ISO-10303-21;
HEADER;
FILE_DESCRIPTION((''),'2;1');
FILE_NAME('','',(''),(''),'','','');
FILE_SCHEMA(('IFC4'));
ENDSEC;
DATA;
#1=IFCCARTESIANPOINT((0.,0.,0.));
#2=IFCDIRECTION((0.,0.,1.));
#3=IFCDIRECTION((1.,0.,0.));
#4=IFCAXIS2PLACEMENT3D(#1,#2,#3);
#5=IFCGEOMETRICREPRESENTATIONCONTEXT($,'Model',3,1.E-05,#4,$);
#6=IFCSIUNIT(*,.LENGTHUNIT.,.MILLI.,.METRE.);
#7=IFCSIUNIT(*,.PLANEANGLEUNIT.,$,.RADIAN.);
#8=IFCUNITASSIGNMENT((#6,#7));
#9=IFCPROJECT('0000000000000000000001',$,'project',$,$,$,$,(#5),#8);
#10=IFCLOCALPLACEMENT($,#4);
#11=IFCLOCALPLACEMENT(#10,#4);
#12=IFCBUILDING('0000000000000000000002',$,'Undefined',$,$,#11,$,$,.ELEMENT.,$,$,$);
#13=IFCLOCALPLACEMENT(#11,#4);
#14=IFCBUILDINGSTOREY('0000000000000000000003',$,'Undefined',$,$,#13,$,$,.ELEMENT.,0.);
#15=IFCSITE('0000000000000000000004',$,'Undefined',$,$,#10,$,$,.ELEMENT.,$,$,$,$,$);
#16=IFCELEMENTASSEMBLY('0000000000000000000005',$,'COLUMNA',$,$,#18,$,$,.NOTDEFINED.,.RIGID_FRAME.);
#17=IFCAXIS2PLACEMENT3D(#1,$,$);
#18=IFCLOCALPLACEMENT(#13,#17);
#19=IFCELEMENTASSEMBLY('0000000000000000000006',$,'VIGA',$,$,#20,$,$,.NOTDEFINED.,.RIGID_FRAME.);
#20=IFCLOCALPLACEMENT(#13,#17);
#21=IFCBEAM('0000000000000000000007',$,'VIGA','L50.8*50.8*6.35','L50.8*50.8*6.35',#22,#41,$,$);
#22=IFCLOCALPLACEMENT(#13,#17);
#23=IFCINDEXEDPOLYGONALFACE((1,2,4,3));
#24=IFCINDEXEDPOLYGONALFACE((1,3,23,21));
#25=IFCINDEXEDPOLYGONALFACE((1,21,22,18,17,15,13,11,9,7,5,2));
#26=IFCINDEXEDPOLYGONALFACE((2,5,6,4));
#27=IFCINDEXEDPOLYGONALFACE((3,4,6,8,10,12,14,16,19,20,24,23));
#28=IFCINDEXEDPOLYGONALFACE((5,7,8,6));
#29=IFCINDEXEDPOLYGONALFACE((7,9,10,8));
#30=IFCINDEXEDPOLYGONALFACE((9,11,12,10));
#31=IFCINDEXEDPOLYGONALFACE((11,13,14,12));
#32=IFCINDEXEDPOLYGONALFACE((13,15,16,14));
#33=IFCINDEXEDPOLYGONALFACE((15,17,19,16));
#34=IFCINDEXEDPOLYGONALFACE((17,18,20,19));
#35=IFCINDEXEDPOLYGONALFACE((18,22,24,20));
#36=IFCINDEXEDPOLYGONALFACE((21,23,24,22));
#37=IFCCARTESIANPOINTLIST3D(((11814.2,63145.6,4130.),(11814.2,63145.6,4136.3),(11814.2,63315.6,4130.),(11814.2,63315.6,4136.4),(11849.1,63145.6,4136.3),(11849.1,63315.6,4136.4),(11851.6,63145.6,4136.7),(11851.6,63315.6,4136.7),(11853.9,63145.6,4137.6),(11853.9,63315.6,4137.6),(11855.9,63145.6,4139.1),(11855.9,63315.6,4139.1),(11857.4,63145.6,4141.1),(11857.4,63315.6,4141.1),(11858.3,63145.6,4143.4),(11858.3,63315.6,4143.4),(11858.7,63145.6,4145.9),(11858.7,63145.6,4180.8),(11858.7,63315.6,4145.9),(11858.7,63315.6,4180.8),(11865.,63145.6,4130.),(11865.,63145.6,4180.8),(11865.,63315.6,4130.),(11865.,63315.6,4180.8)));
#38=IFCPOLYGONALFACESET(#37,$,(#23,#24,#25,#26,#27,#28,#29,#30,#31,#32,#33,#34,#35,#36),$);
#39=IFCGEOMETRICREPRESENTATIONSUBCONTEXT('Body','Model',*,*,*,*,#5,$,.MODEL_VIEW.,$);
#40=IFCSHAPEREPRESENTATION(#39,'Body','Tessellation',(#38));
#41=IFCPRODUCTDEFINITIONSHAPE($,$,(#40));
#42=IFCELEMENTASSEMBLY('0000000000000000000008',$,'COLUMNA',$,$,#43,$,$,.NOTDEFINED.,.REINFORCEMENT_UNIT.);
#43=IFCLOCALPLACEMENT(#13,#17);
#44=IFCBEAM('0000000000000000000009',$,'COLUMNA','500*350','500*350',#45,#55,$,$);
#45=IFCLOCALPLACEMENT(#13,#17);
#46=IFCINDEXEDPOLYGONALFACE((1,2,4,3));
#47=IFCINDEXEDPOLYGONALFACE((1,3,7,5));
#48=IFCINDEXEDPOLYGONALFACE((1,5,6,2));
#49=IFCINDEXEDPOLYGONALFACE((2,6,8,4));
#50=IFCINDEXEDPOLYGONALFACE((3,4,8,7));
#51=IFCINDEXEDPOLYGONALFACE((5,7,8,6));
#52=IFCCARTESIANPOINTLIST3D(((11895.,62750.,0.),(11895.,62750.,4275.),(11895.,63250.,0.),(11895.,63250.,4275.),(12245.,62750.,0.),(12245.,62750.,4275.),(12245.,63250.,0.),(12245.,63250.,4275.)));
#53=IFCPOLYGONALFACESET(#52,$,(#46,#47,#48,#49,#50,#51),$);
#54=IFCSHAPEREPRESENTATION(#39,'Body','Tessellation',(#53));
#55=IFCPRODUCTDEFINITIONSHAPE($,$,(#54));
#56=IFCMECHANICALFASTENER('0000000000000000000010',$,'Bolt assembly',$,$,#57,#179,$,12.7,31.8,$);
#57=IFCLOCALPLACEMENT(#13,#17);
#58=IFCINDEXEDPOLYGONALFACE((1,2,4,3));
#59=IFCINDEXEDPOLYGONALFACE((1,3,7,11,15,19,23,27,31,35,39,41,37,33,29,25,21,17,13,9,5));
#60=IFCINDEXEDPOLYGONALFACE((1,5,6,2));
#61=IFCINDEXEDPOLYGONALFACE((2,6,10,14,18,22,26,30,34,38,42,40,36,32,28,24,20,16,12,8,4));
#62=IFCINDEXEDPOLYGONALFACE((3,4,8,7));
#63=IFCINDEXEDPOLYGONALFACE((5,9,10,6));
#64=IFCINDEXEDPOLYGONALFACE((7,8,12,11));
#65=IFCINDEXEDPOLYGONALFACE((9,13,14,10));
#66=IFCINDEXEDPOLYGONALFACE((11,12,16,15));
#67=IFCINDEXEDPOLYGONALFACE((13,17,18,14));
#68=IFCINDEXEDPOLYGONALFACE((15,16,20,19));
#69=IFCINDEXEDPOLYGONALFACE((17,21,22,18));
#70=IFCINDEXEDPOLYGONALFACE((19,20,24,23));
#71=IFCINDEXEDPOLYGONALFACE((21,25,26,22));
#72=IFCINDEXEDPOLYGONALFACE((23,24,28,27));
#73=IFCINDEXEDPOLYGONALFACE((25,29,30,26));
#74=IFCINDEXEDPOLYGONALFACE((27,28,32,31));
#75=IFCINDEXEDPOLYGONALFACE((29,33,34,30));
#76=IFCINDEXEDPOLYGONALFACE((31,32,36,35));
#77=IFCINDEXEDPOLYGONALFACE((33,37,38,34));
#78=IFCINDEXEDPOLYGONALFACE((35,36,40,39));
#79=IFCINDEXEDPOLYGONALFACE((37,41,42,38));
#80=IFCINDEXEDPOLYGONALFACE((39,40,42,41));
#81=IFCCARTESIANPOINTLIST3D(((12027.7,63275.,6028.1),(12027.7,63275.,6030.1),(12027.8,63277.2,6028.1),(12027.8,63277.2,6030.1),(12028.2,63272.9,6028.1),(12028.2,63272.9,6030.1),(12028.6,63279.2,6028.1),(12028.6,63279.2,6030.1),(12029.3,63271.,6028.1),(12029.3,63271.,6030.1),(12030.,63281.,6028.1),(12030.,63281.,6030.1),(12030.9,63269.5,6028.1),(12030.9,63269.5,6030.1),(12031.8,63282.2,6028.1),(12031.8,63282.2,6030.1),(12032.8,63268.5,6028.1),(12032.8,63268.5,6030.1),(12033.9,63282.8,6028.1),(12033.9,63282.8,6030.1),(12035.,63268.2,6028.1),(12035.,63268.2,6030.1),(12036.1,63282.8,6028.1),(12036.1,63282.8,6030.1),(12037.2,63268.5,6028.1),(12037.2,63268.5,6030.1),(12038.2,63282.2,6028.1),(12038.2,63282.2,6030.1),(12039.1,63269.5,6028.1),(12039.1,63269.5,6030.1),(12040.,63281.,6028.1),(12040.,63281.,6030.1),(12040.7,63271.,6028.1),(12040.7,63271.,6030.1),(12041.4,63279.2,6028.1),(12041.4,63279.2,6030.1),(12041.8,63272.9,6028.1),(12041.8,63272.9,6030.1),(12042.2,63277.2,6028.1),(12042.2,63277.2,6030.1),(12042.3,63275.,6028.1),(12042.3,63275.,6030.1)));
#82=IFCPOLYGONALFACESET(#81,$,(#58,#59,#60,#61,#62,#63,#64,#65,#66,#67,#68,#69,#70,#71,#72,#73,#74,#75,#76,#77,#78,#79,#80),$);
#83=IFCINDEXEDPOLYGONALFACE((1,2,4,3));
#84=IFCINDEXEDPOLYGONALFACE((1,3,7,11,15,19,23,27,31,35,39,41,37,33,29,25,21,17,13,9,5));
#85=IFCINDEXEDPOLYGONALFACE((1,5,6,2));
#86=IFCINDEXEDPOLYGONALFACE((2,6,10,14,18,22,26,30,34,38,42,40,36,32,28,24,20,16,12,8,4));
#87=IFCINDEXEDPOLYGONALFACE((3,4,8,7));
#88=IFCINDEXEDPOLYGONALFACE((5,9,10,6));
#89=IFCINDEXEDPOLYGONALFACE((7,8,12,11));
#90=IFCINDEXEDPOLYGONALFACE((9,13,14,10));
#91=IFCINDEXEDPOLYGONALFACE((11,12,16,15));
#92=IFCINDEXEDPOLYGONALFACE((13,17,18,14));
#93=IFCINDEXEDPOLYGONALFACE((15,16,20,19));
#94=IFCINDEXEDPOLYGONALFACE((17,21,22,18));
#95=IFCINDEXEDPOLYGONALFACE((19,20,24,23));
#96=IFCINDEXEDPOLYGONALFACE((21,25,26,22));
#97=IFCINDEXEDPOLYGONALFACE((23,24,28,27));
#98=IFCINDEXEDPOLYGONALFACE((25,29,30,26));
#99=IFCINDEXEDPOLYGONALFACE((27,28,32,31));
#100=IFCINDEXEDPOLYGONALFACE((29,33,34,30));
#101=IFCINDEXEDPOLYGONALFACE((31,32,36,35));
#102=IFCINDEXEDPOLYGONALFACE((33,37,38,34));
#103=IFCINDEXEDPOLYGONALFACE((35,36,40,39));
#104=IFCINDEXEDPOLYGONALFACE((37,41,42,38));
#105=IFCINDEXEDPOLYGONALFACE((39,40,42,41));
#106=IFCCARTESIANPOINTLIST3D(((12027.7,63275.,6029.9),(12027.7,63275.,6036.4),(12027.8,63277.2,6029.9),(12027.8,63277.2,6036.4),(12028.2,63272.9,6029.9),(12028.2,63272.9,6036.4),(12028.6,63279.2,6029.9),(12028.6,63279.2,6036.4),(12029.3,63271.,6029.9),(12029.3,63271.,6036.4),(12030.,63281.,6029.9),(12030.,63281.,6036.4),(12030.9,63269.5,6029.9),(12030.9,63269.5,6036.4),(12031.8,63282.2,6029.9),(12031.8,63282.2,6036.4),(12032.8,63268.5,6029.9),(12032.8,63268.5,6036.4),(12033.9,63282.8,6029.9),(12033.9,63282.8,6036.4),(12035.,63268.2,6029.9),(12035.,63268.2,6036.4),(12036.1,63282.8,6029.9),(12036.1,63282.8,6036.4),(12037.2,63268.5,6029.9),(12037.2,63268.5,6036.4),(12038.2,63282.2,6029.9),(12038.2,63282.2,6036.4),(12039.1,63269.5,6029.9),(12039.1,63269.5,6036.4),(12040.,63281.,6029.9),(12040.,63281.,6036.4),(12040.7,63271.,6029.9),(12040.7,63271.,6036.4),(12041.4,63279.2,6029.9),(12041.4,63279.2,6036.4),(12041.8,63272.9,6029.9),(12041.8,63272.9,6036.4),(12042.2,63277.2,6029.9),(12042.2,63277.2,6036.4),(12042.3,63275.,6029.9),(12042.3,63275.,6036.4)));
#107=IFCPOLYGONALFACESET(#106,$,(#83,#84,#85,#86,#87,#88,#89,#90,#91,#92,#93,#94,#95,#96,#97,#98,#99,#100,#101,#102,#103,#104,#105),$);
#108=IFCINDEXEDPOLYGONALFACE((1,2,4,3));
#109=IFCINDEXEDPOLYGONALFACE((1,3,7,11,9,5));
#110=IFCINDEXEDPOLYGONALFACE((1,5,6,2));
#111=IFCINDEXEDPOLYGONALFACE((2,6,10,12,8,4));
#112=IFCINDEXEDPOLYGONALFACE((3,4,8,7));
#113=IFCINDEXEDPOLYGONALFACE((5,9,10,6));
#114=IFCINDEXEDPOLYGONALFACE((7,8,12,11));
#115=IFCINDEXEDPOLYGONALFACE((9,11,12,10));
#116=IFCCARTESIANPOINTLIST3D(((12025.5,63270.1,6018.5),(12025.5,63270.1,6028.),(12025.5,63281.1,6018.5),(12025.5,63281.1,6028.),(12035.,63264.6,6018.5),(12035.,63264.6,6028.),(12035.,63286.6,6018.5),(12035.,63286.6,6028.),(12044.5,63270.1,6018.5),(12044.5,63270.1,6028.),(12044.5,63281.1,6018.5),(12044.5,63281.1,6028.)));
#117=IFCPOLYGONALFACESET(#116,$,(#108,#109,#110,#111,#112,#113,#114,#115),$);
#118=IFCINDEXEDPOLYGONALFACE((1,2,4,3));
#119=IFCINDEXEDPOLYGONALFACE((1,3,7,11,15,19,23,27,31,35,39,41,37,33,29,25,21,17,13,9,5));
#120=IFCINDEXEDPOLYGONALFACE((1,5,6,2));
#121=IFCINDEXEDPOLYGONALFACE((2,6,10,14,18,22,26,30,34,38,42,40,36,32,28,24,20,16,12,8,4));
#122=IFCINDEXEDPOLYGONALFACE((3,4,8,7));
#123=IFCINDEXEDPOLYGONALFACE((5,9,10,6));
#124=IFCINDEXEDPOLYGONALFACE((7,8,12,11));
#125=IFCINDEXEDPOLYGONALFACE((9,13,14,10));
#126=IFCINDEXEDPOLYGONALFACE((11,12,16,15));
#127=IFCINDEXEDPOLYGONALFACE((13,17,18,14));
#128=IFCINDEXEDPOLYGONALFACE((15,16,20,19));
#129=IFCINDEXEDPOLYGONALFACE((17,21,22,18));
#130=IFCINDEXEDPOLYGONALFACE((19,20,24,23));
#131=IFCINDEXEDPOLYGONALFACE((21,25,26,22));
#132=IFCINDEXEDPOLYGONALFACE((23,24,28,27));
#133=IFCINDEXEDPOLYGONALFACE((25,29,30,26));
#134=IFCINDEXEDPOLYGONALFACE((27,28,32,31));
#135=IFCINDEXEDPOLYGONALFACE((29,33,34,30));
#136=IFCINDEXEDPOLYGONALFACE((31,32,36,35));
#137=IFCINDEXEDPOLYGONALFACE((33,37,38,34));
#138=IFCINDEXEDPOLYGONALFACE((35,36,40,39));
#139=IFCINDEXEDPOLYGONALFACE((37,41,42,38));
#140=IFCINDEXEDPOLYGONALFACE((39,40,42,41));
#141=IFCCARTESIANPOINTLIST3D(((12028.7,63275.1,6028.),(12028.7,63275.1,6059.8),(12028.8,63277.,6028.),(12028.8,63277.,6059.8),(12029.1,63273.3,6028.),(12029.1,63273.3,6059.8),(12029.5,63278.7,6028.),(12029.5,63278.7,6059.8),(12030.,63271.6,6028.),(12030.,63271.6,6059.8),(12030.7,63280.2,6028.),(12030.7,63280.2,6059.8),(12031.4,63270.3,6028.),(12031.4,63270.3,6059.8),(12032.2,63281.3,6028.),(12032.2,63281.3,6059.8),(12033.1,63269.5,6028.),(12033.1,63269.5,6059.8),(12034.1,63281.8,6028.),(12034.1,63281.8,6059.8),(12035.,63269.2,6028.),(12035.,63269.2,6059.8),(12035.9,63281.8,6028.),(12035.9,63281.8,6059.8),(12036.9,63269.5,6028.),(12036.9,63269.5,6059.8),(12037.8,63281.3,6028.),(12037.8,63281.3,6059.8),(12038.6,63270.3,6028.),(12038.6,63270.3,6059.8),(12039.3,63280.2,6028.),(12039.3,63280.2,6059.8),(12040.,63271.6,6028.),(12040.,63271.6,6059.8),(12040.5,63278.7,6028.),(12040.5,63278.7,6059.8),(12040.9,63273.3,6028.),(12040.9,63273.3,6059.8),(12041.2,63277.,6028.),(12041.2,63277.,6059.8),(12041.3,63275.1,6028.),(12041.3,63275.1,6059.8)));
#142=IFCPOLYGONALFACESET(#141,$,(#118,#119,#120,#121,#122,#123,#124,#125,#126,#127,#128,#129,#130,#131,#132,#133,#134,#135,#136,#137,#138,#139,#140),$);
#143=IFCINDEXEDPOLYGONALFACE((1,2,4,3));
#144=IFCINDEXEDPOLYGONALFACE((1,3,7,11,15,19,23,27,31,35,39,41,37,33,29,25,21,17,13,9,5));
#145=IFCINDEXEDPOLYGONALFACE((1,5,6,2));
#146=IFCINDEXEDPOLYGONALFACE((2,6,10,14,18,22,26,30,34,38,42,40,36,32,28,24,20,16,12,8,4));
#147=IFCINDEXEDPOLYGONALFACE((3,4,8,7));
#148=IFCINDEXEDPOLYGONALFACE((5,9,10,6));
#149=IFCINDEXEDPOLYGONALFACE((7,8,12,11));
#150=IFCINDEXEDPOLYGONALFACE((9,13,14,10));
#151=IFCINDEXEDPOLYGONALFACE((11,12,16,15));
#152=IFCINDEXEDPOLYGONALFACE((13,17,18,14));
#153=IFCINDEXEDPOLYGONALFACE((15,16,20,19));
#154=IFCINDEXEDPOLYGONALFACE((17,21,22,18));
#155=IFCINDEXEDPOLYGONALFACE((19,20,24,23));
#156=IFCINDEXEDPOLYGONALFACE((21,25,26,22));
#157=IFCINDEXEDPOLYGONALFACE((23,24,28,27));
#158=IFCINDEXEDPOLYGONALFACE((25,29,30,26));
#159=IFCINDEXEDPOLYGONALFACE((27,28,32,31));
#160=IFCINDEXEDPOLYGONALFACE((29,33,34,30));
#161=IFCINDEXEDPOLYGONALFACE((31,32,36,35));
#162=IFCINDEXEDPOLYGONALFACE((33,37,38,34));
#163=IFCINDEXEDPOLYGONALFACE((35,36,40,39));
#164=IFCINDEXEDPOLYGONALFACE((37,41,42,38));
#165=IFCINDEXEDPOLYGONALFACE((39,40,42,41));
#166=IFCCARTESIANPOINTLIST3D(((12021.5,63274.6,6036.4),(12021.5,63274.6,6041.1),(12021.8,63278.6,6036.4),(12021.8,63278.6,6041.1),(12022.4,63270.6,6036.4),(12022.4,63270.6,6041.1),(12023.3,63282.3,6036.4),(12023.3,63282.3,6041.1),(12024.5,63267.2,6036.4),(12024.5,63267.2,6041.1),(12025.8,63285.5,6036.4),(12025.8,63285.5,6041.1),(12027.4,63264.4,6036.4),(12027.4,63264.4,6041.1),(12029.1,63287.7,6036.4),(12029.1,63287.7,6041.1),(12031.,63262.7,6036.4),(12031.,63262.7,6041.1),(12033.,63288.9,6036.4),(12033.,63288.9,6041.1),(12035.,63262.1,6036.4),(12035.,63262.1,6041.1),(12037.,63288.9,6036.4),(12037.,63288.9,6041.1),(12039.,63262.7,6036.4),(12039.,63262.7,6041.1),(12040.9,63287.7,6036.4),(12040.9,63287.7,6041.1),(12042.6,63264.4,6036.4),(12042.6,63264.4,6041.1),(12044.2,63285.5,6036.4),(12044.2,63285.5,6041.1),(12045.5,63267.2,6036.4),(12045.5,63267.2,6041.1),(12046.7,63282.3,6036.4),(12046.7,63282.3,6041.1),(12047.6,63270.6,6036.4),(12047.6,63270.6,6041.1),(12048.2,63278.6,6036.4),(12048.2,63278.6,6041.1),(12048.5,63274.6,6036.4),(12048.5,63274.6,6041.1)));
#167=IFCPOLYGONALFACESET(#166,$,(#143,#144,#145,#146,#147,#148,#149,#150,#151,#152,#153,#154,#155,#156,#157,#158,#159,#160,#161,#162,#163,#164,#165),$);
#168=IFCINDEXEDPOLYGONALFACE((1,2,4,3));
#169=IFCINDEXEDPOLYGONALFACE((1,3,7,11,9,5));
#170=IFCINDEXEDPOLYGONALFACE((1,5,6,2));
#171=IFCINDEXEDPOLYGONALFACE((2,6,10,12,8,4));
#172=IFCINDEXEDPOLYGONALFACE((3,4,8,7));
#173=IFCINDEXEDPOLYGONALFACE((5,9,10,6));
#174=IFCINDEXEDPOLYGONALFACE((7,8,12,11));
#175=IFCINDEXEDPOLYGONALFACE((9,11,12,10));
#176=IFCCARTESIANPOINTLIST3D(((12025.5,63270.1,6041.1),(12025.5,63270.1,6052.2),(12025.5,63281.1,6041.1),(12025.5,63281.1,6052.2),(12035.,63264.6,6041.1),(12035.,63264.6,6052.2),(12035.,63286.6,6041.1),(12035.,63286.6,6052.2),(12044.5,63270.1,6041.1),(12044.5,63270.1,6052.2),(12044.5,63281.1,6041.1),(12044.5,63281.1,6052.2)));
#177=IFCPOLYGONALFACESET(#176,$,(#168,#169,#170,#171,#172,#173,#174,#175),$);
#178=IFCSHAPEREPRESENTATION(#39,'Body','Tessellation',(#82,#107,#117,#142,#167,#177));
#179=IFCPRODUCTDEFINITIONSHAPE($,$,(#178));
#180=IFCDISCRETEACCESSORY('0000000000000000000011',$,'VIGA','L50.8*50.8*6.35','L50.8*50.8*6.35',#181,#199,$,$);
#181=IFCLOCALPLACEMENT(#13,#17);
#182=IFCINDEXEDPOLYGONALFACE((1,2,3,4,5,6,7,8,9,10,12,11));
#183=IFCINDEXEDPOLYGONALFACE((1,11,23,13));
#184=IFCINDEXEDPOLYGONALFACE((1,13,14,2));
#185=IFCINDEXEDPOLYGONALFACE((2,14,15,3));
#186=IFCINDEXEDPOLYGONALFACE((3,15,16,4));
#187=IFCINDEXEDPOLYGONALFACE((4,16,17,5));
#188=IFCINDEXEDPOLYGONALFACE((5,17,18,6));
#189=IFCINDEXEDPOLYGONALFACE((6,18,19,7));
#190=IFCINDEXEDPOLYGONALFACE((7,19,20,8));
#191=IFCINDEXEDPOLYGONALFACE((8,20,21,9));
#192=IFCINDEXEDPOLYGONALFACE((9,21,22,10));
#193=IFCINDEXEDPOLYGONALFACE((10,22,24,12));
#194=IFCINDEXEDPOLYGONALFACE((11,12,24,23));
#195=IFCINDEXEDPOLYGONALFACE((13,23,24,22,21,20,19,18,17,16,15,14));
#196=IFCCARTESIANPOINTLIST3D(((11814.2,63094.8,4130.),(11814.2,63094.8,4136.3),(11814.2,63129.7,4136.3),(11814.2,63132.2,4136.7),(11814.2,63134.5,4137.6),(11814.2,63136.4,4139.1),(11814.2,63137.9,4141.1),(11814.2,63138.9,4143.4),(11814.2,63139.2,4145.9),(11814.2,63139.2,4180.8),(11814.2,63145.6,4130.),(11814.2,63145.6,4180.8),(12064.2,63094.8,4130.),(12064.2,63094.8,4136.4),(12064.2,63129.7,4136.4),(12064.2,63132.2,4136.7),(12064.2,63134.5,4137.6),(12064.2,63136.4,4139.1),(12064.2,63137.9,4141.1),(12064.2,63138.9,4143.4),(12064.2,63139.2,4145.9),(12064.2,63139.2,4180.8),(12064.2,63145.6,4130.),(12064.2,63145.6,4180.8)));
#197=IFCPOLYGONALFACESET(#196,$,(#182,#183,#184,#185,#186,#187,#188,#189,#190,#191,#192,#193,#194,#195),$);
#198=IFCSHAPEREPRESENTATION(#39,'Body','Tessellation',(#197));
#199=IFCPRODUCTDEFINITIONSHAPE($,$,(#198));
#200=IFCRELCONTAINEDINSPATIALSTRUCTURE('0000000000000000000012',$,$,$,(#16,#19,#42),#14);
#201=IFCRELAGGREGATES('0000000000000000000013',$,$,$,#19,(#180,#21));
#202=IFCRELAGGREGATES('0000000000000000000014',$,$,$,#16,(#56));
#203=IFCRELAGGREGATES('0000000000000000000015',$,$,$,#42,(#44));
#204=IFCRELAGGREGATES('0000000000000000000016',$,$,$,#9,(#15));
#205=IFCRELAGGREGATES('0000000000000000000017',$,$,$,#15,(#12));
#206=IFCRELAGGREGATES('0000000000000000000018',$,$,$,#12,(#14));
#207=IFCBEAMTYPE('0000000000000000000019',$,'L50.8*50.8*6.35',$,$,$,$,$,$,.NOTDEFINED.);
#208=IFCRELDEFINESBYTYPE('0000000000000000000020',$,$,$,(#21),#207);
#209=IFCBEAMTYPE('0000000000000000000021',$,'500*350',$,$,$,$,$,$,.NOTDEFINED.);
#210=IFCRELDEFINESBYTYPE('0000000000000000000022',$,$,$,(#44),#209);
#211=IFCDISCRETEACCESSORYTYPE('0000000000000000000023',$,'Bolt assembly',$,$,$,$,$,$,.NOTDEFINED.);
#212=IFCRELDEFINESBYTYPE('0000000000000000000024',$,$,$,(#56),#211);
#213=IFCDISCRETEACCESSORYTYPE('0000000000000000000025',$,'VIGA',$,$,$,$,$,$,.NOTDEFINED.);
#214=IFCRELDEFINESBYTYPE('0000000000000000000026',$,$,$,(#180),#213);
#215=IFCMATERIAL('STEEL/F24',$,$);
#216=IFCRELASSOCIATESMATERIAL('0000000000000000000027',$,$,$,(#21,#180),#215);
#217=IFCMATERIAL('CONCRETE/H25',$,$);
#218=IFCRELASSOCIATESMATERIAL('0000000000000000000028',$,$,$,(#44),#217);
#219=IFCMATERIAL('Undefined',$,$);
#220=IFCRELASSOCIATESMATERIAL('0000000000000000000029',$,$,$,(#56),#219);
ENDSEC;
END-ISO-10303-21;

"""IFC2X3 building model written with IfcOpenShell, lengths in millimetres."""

from ifc_helpers import new_model, si_unit, frame, origin_with_axes, origin_2d_with_axis, place, context, subcontext, project, spatial, polyline, rectangle, circle, l_section, outline, extrude, source, transform, mapped, material, type_object, element, aggregate, save


model = new_model("IFC2X3")

# Units and contexts
model_context = context("Model", 3, precision=1e-05, world=origin_with_axes())
body_context = subcontext(model_context, "Body", "Model", "MODEL_VIEW")
ifc_project = project(units=[si_unit("LENGTHUNIT", "METRE", prefix="MILLI"), si_unit("PLANEANGLEUNIT", "RADIAN")], contexts=[model_context])

# Site, building, storey
site_placement = place(None, origin_with_axes())
site = spatial("IfcSite", under=ifc_project, at=site_placement, Name="Undefined", CompositionType="ELEMENT")
building_placement = place(site_placement, origin_with_axes())
building = spatial("IfcBuilding", under=site, at=building_placement, Name="Undefined", CompositionType="ELEMENT")
storey_placement = place(building_placement, origin_with_axes())
storey = spatial("IfcBuildingStorey", under=building, at=storey_placement, Name="Undefined", CompositionType="ELEMENT", Elevation=0.0)

# Element assembly
assembly_1_placement = place(storey_placement, origin_with_axes())
assembly_1 = element("IfcElementAssembly", 1, at=assembly_1_placement, inside=storey, Name="COLUMNA", AssemblyPlace="NOTDEFINED", PredefinedType="RIGID_FRAME")
ifc_material_1 = material(Name="STEEL/F24")

# Element assemblies, beams
assembly_2_placement = place(storey_placement, origin_with_axes())
assembly_2 = element("IfcElementAssembly", 2, at=assembly_2_placement, inside=storey, Name="VIGA", AssemblyPlace="NOTDEFINED", PredefinedType="RIGID_FRAME")
beam_type_1 = type_object("IfcBeamType", Name="L50.8*50.8*6.35", PredefinedType="NOTDEFINED")
beam_1_placement = place(assembly_2_placement, frame((11839.6, 63145.6, 4155.4), z_axis=(-1.0, 0.000017, 0.0), x_axis=(0.000017, 1.0, 0.000015)))
beam_1 = element("IfcBeam", 3, at=beam_1_placement, type_object=beam_type_1, material=ifc_material_1, Name="VIGA", Description="L50.8*50.8*6.35", ObjectType="L50.8*50.8*6.35", context=body_context, shape_type="SweptSolid", body=[
    extrude(l_section(Depth=50.8, Width=50.8, Thickness=6.3, FilletRadius=9.5, at=origin_2d_with_axis()), frame((170.0, 0.0, 0.0), z_axis=(-1.0, 0.0, 0.0), x_axis=(0.0, -1.0, 0.0)), (0.0, 0.0, 1.0), 170.0),
])
assembly_3_placement = place(storey_placement, origin_with_axes())
assembly_3 = element("IfcElementAssembly", 4, at=assembly_3_placement, inside=storey, Name="COLUMNA", AssemblyPlace="NOTDEFINED", PredefinedType="REINFORCEMENT_UNIT")
ifc_material_2 = material(Name="CONCRETE/H25")
beam_type_2 = type_object("IfcBeamType", Name="500*350", PredefinedType="NOTDEFINED")
beam_2_placement = place(assembly_3_placement, frame((12070.0, 63000.0, 4275.0), z_axis=(0.0, -1.0, 0.0), x_axis=(0.0, 0.0, -1.0)))
beam_2 = element("IfcBeam", 5, at=beam_2_placement, type_object=beam_type_2, material=ifc_material_2, Name="COLUMNA", Description="500*350", ObjectType="500*350", context=body_context, shape_type="SweptSolid", body=[
    extrude(rectangle(XDim=350.0, YDim=500.0, at=origin_2d_with_axis()), frame((4275.0, 0.0, 0.0), z_axis=(-1.0, 0.0, 0.0), x_axis=(0.0, -1.0, 0.0)), (0.0, 0.0, 1.0), 4275.0),
])

# Mechanical fastener
ifc_material_3 = material(Name="Undefined")
discrete_accessory_type_1 = type_object("IfcDiscreteAccessoryType", Name="Bolt assembly")
shared_shape_1 = source(origin_with_axes(), body_context, "Body", "SweptSolid", [
    extrude(circle(Radius=7.3, at=origin_2d_with_axis()), frame((0.0, 0.6, 0.0), z_axis=(0.0, 1.0, 0.0), x_axis=(1.0, 0.0, 0.0)), (0.0, 0.0, 1.0), 2.0),
    extrude(circle(Radius=7.3, at=origin_2d_with_axis()), frame((0.0, 2.4, 0.0), z_axis=(0.0, 1.0, 0.0), x_axis=(1.0, 0.0, 0.0)), (0.0, 0.0, 1.0), 6.5),
    extrude(outline(polyline([(11.0, 0.0), (5.5, 9.5), (-5.5, 9.5), (-11.0, 0.0), (-5.5, -9.5), (5.5, -9.5), (11.0, 0.0)])), frame((0.0, -9.0, 0.0), z_axis=(0.0, 1.0, 0.0), x_axis=(1.0, 0.0, 0.0)), (0.0, 0.0, 1.0), 9.5),
    extrude(circle(Radius=6.3, at=origin_2d_with_axis()), frame((0.0, 0.5, 0.0), z_axis=(0.0, 1.0, 0.0), x_axis=(1.0, 0.0, 0.0)), (0.0, 0.0, 1.0), 31.8),
    extrude(circle(Radius=13.5, at=origin_2d_with_axis()), frame((0.0, 8.9, 0.0), z_axis=(0.0, 1.0, 0.0), x_axis=(1.0, 0.0, 0.0)), (0.0, 0.0, 1.0), 4.8),
    extrude(outline(polyline([(11.0, 0.0), (5.5, 9.5), (-5.5, 9.5), (-11.0, 0.0), (-5.5, -9.5), (5.5, -9.5), (11.0, 0.0)])), frame((0.0, 13.6, 0.0), z_axis=(0.0, 1.0, 0.0), x_axis=(1.0, 0.0, 0.0)), (0.0, 0.0, 1.0), 11.1),
])
mechanical_fastener_1_placement = place(assembly_1_placement, frame((12035.0, 63275.6, 6027.5), z_axis=(-1.0, 0.0, 0.0), x_axis=(0.0, -1.0, 0.0)))
mechanical_fastener_1 = element("IfcMechanicalFastener", 6, at=mechanical_fastener_1_placement, type_object=discrete_accessory_type_1, material=ifc_material_3, Name="Bolt assembly", NominalDiameter=12.7, NominalLength=31.8, context=body_context, shape_type="MappedRepresentation", body=[
    mapped(shared_shape_1, transform((0.0, 0.0, 0.0))),
])

# Discrete accessory
discrete_accessory_type_2 = type_object("IfcDiscreteAccessoryType", Name="VIGA")
discrete_accessory_1_placement = place(assembly_2_placement, frame((11814.2, 63120.2, 4155.4), z_axis=(-0.000015, 0.0, 1.0), x_axis=(1.0, -0.000017, 0.000015)))
discrete_accessory_1 = element("IfcDiscreteAccessory", 7, at=discrete_accessory_1_placement, type_object=discrete_accessory_type_2, material=ifc_material_1, Name="VIGA", Description="L50.8*50.8*6.35", ObjectType="L50.8*50.8*6.35", context=body_context, shape_type="SweptSolid", body=[
    extrude(l_section(Depth=50.8, Width=50.8, Thickness=6.3, FilletRadius=9.5, at=origin_2d_with_axis()), frame((250.0, 0.0, 0.0), z_axis=(-1.0, 0.0, 0.0), x_axis=(0.0, -1.0, 0.0)), (0.0, 0.0, 1.0), 250.0),
])
aggregate(assembly_2, [discrete_accessory_1, beam_1])

aggregate(assembly_1, [mechanical_fastener_1])

aggregate(assembly_3, [beam_2])

save(model, "model.ifc")
